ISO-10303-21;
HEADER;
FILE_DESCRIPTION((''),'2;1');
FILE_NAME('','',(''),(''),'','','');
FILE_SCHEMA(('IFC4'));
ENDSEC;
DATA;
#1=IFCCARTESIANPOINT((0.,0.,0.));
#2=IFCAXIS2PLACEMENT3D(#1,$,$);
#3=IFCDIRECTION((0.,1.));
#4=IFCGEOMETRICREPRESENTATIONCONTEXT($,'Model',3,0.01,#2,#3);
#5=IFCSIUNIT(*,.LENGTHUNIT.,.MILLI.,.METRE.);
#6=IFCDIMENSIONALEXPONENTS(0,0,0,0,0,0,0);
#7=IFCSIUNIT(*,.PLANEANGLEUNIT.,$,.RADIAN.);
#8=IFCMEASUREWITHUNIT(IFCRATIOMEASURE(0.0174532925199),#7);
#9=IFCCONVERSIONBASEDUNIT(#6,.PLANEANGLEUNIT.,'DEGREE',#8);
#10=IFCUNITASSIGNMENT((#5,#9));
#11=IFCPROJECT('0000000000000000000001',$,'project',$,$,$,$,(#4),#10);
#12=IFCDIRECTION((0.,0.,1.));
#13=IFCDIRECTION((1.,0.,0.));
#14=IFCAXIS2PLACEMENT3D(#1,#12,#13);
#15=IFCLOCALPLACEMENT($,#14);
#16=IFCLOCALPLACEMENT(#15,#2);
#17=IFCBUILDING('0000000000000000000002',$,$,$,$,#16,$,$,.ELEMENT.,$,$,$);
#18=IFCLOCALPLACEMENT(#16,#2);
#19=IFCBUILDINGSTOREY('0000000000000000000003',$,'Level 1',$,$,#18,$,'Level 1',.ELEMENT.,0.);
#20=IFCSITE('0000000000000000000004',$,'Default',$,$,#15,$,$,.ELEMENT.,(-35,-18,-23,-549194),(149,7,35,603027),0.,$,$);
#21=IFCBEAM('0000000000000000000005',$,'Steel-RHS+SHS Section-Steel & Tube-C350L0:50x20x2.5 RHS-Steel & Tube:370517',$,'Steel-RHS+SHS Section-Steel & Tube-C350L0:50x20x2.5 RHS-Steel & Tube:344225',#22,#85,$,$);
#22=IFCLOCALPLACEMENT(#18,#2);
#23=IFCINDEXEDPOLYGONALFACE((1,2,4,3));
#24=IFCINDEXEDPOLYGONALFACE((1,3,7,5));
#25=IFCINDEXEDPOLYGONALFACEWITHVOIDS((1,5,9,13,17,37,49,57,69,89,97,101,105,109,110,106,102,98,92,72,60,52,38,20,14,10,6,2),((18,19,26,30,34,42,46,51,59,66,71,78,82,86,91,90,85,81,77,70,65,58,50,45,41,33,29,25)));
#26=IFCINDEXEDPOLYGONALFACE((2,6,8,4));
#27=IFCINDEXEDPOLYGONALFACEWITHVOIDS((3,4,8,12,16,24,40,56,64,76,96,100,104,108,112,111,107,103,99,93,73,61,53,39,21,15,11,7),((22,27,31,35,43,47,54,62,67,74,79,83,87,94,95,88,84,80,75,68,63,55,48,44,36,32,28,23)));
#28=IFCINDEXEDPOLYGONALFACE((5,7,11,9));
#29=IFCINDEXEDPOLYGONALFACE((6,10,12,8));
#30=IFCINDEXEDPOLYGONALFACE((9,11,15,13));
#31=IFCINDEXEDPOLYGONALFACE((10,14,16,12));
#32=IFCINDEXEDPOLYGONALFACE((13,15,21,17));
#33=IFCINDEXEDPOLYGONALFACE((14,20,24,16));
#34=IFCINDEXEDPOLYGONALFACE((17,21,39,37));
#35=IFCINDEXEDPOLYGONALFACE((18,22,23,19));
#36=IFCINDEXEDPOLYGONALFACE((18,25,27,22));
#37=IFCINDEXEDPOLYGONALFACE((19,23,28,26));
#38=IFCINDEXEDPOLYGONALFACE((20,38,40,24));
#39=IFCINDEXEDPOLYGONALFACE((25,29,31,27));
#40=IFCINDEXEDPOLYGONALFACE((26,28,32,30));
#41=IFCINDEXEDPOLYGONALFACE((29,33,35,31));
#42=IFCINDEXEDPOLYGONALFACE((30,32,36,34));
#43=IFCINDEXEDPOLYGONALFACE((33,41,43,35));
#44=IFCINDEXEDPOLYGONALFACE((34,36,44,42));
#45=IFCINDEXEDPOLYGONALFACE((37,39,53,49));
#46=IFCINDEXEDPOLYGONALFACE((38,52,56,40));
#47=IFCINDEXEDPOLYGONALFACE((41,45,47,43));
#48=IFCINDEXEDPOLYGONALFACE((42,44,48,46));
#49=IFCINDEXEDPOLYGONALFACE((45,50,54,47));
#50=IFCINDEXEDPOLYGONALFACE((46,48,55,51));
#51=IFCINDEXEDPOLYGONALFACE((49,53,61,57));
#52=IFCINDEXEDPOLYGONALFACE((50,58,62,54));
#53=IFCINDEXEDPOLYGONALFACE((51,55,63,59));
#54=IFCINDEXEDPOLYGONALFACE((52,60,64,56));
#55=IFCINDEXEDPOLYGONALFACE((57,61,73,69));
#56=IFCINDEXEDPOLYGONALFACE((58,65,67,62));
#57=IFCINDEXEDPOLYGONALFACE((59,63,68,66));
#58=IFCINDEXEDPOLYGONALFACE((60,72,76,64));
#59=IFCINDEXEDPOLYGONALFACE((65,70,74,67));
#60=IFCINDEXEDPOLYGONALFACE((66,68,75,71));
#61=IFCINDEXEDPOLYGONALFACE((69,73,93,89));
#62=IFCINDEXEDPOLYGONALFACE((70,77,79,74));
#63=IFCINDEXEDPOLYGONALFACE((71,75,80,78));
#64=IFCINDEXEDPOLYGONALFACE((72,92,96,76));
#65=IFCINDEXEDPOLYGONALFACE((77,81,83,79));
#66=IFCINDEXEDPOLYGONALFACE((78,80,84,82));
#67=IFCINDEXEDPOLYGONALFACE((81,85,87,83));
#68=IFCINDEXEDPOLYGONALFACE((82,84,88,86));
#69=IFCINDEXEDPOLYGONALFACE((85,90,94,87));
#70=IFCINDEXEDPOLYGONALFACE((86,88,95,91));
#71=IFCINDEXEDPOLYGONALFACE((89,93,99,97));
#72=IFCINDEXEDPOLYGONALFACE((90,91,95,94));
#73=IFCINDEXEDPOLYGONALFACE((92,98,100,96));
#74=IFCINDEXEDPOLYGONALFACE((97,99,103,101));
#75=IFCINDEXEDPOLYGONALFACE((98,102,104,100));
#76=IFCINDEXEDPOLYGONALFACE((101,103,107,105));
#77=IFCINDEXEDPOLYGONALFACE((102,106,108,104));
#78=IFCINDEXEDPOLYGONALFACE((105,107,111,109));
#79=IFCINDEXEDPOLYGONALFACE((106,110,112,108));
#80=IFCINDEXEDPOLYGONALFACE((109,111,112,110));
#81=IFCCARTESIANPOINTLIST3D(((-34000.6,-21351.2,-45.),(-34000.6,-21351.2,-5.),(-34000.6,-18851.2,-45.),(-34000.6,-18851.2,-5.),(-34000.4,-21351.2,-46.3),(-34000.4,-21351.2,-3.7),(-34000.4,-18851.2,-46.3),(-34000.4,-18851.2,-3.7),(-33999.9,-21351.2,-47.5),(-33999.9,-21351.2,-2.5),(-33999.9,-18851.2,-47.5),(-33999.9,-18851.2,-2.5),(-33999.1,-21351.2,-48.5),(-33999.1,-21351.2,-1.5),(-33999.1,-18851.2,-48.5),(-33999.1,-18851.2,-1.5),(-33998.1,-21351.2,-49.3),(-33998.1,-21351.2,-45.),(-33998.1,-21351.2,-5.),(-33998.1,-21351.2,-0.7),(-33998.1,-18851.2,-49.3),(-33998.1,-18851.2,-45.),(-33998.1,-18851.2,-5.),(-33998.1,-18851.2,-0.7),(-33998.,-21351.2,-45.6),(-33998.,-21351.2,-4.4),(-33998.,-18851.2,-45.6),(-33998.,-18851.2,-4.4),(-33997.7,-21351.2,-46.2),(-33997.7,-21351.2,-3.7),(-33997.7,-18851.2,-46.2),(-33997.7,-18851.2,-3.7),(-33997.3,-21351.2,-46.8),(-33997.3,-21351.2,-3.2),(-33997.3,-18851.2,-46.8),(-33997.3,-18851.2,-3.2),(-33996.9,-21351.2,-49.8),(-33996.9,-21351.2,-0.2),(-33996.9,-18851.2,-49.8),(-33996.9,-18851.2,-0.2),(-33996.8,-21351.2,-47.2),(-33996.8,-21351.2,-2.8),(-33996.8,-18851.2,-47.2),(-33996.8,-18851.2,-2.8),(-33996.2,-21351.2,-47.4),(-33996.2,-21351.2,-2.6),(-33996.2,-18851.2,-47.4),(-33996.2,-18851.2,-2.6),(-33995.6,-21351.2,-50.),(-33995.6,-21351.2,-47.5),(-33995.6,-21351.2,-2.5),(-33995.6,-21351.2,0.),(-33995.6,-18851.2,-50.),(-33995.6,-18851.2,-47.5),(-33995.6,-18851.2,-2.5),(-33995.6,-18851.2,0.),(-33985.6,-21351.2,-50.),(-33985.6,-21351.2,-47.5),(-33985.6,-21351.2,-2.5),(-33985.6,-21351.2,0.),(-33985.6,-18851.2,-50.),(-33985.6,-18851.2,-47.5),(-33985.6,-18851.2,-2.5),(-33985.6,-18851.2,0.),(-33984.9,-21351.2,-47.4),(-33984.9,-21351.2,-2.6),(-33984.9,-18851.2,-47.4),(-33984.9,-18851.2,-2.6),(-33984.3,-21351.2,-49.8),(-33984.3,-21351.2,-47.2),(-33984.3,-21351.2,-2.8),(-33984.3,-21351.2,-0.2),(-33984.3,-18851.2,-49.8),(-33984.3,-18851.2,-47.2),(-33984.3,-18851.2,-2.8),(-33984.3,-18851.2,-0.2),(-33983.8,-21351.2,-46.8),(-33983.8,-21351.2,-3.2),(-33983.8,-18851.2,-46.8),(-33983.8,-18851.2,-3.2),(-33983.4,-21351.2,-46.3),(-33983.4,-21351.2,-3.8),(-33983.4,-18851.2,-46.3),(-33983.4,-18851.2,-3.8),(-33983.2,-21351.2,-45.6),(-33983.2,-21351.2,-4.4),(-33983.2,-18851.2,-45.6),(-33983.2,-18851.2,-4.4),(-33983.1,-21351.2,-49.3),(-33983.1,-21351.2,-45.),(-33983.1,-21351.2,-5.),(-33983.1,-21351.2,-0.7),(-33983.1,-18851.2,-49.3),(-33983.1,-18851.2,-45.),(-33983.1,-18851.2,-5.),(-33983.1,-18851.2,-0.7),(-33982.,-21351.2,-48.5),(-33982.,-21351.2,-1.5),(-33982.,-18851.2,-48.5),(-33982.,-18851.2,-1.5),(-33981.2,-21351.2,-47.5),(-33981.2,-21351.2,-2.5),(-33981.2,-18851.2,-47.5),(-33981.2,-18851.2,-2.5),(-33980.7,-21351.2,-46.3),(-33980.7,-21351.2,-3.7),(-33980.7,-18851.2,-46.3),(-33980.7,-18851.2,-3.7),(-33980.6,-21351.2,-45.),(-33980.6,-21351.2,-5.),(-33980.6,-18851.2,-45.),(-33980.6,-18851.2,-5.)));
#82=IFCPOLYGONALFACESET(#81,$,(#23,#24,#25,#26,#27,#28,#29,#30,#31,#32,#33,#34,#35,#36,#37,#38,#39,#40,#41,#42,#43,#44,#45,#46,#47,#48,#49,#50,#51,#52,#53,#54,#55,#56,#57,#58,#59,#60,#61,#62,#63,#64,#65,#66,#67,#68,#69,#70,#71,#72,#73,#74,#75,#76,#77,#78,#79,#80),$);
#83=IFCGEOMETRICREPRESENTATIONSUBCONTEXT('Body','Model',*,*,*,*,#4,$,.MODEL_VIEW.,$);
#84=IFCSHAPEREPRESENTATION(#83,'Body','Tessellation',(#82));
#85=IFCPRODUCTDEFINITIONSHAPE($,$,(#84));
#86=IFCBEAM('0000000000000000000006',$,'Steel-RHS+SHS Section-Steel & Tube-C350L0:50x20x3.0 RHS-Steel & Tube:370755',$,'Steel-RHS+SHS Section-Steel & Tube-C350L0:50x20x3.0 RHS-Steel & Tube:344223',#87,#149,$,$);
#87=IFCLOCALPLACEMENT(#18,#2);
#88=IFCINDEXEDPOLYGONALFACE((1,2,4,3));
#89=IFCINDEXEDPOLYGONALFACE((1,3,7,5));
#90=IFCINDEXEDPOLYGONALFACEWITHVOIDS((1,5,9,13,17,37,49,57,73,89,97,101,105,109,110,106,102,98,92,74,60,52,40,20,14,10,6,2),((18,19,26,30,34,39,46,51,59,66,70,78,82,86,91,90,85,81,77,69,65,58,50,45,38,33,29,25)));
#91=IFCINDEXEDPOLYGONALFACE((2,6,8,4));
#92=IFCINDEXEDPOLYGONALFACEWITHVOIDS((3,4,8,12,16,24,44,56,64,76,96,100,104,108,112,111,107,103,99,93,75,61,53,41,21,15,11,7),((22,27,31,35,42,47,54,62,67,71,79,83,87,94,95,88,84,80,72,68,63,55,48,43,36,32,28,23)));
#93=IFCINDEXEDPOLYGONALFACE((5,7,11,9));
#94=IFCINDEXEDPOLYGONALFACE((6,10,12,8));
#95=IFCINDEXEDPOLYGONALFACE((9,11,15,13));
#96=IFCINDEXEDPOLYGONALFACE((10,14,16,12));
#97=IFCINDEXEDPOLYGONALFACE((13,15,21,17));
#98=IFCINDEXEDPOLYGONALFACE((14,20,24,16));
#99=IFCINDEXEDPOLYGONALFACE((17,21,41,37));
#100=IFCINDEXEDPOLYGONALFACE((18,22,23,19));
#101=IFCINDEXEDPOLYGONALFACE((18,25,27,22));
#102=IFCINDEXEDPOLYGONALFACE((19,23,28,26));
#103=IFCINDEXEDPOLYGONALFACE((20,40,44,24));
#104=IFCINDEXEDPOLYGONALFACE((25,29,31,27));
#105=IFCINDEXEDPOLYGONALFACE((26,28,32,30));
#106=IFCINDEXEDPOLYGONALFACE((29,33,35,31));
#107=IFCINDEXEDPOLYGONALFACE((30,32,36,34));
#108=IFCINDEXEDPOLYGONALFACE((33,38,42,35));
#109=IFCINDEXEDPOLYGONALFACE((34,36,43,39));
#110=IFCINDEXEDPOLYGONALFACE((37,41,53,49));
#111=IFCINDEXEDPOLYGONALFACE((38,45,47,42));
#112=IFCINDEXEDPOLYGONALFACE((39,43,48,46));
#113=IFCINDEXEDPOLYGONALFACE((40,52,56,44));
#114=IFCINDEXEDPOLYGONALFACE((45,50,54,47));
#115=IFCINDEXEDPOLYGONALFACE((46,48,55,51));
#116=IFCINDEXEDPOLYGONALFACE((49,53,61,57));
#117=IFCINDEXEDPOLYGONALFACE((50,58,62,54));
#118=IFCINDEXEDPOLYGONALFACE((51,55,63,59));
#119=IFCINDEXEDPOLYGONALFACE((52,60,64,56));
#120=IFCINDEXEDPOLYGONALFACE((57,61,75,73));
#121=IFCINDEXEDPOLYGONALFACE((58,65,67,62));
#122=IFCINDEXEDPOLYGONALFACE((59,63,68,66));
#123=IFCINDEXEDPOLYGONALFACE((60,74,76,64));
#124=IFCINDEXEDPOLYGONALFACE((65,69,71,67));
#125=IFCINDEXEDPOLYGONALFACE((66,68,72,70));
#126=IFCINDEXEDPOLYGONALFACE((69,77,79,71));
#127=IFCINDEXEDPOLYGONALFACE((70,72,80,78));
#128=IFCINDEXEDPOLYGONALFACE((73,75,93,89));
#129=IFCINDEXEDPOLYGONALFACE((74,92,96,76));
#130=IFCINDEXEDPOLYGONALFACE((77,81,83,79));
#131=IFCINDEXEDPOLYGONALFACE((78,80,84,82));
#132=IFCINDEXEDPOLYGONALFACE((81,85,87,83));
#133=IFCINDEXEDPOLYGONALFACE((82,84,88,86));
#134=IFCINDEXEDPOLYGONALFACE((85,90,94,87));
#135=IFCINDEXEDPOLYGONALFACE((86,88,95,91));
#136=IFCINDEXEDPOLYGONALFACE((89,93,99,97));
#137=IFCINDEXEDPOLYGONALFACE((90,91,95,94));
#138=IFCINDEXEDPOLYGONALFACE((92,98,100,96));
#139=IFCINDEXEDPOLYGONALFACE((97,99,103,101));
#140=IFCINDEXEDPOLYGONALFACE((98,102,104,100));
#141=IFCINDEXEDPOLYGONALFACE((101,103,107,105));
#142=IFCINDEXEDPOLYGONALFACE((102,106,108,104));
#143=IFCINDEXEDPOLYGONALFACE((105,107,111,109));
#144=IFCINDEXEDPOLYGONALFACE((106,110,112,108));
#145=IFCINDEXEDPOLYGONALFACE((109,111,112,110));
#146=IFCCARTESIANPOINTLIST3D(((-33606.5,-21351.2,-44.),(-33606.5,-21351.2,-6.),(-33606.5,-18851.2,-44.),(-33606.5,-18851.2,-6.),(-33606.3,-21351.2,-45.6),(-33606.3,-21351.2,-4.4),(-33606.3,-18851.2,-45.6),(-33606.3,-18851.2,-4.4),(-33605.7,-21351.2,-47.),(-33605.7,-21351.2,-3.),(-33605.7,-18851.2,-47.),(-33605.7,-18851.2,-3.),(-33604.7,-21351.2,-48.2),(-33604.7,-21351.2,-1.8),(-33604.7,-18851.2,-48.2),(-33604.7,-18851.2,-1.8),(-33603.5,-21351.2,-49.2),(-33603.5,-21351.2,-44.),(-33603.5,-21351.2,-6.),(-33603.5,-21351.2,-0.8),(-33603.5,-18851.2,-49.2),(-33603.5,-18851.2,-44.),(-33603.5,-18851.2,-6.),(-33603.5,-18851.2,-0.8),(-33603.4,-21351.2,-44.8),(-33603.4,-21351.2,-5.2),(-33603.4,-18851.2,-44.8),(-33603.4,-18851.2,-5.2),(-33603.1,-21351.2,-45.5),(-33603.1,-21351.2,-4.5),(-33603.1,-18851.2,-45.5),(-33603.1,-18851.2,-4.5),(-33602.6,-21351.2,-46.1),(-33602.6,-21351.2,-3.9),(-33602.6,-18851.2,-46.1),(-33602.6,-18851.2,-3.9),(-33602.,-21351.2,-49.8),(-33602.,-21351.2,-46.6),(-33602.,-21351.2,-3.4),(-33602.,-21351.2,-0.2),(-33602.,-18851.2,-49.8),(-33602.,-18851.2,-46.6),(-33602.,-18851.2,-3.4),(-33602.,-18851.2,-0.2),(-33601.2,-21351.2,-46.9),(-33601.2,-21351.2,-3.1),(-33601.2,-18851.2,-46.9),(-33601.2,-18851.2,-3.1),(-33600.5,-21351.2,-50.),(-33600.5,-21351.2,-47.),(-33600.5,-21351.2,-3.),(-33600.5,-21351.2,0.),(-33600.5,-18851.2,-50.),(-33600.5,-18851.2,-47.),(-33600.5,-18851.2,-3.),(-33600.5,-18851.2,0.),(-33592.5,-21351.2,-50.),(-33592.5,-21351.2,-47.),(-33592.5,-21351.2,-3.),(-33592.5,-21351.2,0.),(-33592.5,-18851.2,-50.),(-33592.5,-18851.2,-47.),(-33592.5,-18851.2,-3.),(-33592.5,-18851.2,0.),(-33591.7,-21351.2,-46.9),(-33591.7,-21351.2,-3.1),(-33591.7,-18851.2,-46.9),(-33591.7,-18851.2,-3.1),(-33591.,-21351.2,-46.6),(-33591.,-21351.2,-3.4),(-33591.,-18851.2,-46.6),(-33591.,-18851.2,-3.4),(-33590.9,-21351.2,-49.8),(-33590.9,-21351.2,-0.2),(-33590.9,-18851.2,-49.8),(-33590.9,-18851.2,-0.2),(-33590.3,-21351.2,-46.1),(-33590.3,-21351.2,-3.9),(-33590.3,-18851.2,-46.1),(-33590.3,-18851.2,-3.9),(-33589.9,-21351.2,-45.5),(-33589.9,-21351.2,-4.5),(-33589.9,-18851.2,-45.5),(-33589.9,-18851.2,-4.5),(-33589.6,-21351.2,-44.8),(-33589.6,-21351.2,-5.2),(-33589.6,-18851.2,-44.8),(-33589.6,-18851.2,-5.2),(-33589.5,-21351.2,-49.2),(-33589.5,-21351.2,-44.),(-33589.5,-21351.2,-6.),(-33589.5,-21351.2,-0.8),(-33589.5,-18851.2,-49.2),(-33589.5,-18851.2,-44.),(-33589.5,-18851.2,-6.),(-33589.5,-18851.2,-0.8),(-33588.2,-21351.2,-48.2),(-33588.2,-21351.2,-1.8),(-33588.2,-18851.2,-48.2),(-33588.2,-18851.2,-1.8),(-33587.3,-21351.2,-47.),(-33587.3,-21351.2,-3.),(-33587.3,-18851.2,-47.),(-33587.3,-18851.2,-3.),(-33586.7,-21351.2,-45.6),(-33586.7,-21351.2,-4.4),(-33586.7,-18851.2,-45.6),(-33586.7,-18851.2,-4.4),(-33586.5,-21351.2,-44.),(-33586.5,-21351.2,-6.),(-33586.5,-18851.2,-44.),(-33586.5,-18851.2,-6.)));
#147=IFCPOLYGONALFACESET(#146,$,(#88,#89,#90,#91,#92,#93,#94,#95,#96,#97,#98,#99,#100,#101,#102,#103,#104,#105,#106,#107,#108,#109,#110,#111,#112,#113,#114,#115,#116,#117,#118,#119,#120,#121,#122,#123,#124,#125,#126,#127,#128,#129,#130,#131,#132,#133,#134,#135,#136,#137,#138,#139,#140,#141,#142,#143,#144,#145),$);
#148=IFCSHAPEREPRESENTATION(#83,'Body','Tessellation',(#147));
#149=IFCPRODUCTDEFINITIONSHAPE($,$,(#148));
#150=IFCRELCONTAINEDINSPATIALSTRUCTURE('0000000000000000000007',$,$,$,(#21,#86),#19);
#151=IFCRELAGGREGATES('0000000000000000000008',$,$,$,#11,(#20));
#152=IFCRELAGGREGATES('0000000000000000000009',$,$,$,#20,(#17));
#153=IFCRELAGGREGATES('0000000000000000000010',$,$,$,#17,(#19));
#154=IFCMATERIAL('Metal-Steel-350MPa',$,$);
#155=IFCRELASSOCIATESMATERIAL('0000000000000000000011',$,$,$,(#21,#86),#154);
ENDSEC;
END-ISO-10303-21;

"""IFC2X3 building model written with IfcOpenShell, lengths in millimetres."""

from ifc_helpers import new_model, entity, si_unit, converted_unit, direction, frame, frame_2d, origin, origin_with_axes, place, context, subcontext, project, spatial, polyline, circle_curve, parameter, trimmed, segment, composite_curve, outline, extrude, material, element, save


model = new_model("IFC2X3")

# Units and contexts
model_context = context("Model", 3, precision=0.01, world=origin(), true_north=direction((0.0, 1.0)))
body_context = subcontext(model_context, "Body", "Model", "MODEL_VIEW")
ifc_project = project(units=[si_unit("LENGTHUNIT", "METRE", prefix="MILLI"), converted_unit("PLANEANGLEUNIT", "DEGREE", entity("IfcRatioMeasure", 0.0174532925199), si_unit("PLANEANGLEUNIT", "RADIAN"), dimensions=[0, 0, 0, 0, 0, 0, 0])], contexts=[model_context])

# Site, building, storey
site_placement = place(None, origin_with_axes())
site = spatial("IfcSite", under=ifc_project, at=site_placement, Name="Default", CompositionType="ELEMENT", RefLatitude=(-35, -18, -23, -549194), RefLongitude=(149, 7, 35, 603027), RefElevation=0.0)
building_placement = place(site_placement, origin())
building = spatial("IfcBuilding", under=site, at=building_placement, CompositionType="ELEMENT")
storey_placement = place(building_placement, origin())
storey = spatial("IfcBuildingStorey", under=building, at=storey_placement, Name="Level 1", LongName="Level 1", CompositionType="ELEMENT", Elevation=0.0)

# Beams
ifc_material = material(Name="Metal-Steel-350MPa")
beam_1_placement = place(storey_placement, frame((-33990.6, -18851.2, 0.0), z_axis=(0.0, 0.0, 1.0), x_axis=(0.0, -1.0, 0.0)))
element("IfcBeam", 1, at=beam_1_placement, inside=storey, material=ifc_material, Name="Steel-RHS+SHS Section-Steel & Tube-C350L0:50x20x2.5 RHS-Steel & Tube:370517", ObjectType="Steel-RHS+SHS Section-Steel & Tube-C350L0:50x20x2.5 RHS-Steel & Tube:344225", context=body_context, shape_type="SweptSolid", body=[
    extrude(outline(composite_curve([segment(trimmed(circle_curve(frame_2d((-5.0, -20.0), x_axis=(1.0, 0.0)), 5.0), [parameter(180.0)], [parameter(270.0)], True, "PARAMETER"), True, "CONTINUOUS"), segment(polyline([(-5.0, -25.0), (5.0, -25.0)]), True, "CONTINUOUS"), segment(trimmed(circle_curve(frame_2d((5.0, -20.0), x_axis=(1.0, 0.0)), 5.0), [parameter(270.0)], [parameter(0.0)], True, "PARAMETER"), True, "CONTINUOUS"), segment(polyline([(10.0, -20.0), (10.0, 20.0)]), True, "CONTINUOUS"), segment(trimmed(circle_curve(frame_2d((5.0, 20.0), x_axis=(1.0, 0.0)), 5.0), [parameter(0.0)], [parameter(90.0)], True, "PARAMETER"), True, "CONTINUOUS"), segment(polyline([(5.0, 25.0), (-5.0, 25.0)]), True, "CONTINUOUS"), segment(trimmed(circle_curve(frame_2d((-5.0, 20.0), x_axis=(1.0, 0.0)), 5.0), [parameter(90.0)], [parameter(180.0)], True, "PARAMETER"), True, "CONTINUOUS"), segment(polyline([(-10.0, 20.0), (-10.0, -20.0)]), True, "CONTINUOUS")], self_intersect=False), holes=[composite_curve([segment(polyline([(5.0, -22.5), (-5.0, -22.5)]), True, "CONTINUOUS"), segment(trimmed(circle_curve(frame_2d((-5.0, -20.0), x_axis=(1.0, 0.0)), 2.5), [parameter(180.0)], [parameter(270.0)], True, "PARAMETER"), False, "CONTINUOUS"), segment(polyline([(-7.5, -20.0), (-7.5, 20.0)]), True, "CONTINUOUS"), segment(trimmed(circle_curve(frame_2d((-5.0, 20.0), x_axis=(1.0, 0.0)), 2.5), [parameter(90.0)], [parameter(180.0)], True, "PARAMETER"), False, "CONTINUOUS"), segment(polyline([(-5.0, 22.5), (5.0, 22.5)]), True, "CONTINUOUS"), segment(trimmed(circle_curve(frame_2d((5.0, 20.0), x_axis=(1.0, 0.0)), 2.5), [parameter(360.0)], [parameter(90.0)], True, "PARAMETER"), False, "CONTINUOUS"), segment(polyline([(7.5, 20.0), (7.5, -20.0)]), True, "CONTINUOUS"), segment(trimmed(circle_curve(frame_2d((5.0, -20.0), x_axis=(1.0, 0.0)), 2.5), [parameter(270.0)], [parameter(0.0)], True, "PARAMETER"), False, "CONTINUOUS")], self_intersect=False)]), frame((0.0, 0.0, -25.0), z_axis=(1.0, 0.0, 0.0), x_axis=(0.0, -1.0, 0.0)), (0.0, 0.0, 1.0), 2500.0),
])
beam_2_placement = place(storey_placement, frame((-33596.5, -18851.2, 0.0), z_axis=(0.0, 0.0, 1.0), x_axis=(0.0, -1.0, 0.0)))
element("IfcBeam", 2, at=beam_2_placement, inside=storey, material=ifc_material, Name="Steel-RHS+SHS Section-Steel & Tube-C350L0:50x20x3.0 RHS-Steel & Tube:370755", ObjectType="Steel-RHS+SHS Section-Steel & Tube-C350L0:50x20x3.0 RHS-Steel & Tube:344223", context=body_context, shape_type="SweptSolid", body=[
    extrude(outline(composite_curve([segment(trimmed(circle_curve(frame_2d((-4.0, -19.0), x_axis=(1.0, 0.0)), 6.0), [parameter(180.0)], [parameter(270.0)], True, "PARAMETER"), True, "CONTINUOUS"), segment(polyline([(-4.0, -25.0), (4.0, -25.0)]), True, "CONTINUOUS"), segment(trimmed(circle_curve(frame_2d((4.0, -19.0), x_axis=(1.0, 0.0)), 6.0), [parameter(270.0)], [parameter(0.0)], True, "PARAMETER"), True, "CONTINUOUS"), segment(polyline([(10.0, -19.0), (10.0, 19.0)]), True, "CONTINUOUS"), segment(trimmed(circle_curve(frame_2d((4.0, 19.0), x_axis=(1.0, 0.0)), 6.0), [parameter(0.0)], [parameter(90.0)], True, "PARAMETER"), True, "CONTINUOUS"), segment(polyline([(4.0, 25.0), (-4.0, 25.0)]), True, "CONTINUOUS"), segment(trimmed(circle_curve(frame_2d((-4.0, 19.0), x_axis=(1.0, 0.0)), 6.0), [parameter(90.0)], [parameter(180.0)], True, "PARAMETER"), True, "CONTINUOUS"), segment(polyline([(-10.0, 19.0), (-10.0, -19.0)]), True, "CONTINUOUS")], self_intersect=False), holes=[composite_curve([segment(polyline([(4.0, -22.0), (-4.0, -22.0)]), True, "CONTINUOUS"), segment(trimmed(circle_curve(frame_2d((-4.0, -19.0), x_axis=(1.0, 0.0)), 3.0), [parameter(180.0)], [parameter(270.0)], True, "PARAMETER"), False, "CONTINUOUS"), segment(polyline([(-7.0, -19.0), (-7.0, 19.0)]), True, "CONTINUOUS"), segment(trimmed(circle_curve(frame_2d((-4.0, 19.0), x_axis=(1.0, 0.0)), 3.0), [parameter(90.0)], [parameter(180.0)], True, "PARAMETER"), False, "CONTINUOUS"), segment(polyline([(-4.0, 22.0), (4.0, 22.0)]), True, "CONTINUOUS"), segment(trimmed(circle_curve(frame_2d((4.0, 19.0), x_axis=(1.0, 0.0)), 3.0), [parameter(360.0)], [parameter(90.0)], True, "PARAMETER"), False, "CONTINUOUS"), segment(polyline([(7.0, 19.0), (7.0, -19.0)]), True, "CONTINUOUS"), segment(trimmed(circle_curve(frame_2d((4.0, -19.0), x_axis=(1.0, 0.0)), 3.0), [parameter(270.0)], [parameter(0.0)], True, "PARAMETER"), False, "CONTINUOUS")], self_intersect=False)]), frame((0.0, 0.0, -25.0), z_axis=(1.0, 0.0, 0.0), x_axis=(0.0, -1.0, 0.0)), (0.0, 0.0, 1.0), 2500.0),
])

save(model, "model.ifc")
